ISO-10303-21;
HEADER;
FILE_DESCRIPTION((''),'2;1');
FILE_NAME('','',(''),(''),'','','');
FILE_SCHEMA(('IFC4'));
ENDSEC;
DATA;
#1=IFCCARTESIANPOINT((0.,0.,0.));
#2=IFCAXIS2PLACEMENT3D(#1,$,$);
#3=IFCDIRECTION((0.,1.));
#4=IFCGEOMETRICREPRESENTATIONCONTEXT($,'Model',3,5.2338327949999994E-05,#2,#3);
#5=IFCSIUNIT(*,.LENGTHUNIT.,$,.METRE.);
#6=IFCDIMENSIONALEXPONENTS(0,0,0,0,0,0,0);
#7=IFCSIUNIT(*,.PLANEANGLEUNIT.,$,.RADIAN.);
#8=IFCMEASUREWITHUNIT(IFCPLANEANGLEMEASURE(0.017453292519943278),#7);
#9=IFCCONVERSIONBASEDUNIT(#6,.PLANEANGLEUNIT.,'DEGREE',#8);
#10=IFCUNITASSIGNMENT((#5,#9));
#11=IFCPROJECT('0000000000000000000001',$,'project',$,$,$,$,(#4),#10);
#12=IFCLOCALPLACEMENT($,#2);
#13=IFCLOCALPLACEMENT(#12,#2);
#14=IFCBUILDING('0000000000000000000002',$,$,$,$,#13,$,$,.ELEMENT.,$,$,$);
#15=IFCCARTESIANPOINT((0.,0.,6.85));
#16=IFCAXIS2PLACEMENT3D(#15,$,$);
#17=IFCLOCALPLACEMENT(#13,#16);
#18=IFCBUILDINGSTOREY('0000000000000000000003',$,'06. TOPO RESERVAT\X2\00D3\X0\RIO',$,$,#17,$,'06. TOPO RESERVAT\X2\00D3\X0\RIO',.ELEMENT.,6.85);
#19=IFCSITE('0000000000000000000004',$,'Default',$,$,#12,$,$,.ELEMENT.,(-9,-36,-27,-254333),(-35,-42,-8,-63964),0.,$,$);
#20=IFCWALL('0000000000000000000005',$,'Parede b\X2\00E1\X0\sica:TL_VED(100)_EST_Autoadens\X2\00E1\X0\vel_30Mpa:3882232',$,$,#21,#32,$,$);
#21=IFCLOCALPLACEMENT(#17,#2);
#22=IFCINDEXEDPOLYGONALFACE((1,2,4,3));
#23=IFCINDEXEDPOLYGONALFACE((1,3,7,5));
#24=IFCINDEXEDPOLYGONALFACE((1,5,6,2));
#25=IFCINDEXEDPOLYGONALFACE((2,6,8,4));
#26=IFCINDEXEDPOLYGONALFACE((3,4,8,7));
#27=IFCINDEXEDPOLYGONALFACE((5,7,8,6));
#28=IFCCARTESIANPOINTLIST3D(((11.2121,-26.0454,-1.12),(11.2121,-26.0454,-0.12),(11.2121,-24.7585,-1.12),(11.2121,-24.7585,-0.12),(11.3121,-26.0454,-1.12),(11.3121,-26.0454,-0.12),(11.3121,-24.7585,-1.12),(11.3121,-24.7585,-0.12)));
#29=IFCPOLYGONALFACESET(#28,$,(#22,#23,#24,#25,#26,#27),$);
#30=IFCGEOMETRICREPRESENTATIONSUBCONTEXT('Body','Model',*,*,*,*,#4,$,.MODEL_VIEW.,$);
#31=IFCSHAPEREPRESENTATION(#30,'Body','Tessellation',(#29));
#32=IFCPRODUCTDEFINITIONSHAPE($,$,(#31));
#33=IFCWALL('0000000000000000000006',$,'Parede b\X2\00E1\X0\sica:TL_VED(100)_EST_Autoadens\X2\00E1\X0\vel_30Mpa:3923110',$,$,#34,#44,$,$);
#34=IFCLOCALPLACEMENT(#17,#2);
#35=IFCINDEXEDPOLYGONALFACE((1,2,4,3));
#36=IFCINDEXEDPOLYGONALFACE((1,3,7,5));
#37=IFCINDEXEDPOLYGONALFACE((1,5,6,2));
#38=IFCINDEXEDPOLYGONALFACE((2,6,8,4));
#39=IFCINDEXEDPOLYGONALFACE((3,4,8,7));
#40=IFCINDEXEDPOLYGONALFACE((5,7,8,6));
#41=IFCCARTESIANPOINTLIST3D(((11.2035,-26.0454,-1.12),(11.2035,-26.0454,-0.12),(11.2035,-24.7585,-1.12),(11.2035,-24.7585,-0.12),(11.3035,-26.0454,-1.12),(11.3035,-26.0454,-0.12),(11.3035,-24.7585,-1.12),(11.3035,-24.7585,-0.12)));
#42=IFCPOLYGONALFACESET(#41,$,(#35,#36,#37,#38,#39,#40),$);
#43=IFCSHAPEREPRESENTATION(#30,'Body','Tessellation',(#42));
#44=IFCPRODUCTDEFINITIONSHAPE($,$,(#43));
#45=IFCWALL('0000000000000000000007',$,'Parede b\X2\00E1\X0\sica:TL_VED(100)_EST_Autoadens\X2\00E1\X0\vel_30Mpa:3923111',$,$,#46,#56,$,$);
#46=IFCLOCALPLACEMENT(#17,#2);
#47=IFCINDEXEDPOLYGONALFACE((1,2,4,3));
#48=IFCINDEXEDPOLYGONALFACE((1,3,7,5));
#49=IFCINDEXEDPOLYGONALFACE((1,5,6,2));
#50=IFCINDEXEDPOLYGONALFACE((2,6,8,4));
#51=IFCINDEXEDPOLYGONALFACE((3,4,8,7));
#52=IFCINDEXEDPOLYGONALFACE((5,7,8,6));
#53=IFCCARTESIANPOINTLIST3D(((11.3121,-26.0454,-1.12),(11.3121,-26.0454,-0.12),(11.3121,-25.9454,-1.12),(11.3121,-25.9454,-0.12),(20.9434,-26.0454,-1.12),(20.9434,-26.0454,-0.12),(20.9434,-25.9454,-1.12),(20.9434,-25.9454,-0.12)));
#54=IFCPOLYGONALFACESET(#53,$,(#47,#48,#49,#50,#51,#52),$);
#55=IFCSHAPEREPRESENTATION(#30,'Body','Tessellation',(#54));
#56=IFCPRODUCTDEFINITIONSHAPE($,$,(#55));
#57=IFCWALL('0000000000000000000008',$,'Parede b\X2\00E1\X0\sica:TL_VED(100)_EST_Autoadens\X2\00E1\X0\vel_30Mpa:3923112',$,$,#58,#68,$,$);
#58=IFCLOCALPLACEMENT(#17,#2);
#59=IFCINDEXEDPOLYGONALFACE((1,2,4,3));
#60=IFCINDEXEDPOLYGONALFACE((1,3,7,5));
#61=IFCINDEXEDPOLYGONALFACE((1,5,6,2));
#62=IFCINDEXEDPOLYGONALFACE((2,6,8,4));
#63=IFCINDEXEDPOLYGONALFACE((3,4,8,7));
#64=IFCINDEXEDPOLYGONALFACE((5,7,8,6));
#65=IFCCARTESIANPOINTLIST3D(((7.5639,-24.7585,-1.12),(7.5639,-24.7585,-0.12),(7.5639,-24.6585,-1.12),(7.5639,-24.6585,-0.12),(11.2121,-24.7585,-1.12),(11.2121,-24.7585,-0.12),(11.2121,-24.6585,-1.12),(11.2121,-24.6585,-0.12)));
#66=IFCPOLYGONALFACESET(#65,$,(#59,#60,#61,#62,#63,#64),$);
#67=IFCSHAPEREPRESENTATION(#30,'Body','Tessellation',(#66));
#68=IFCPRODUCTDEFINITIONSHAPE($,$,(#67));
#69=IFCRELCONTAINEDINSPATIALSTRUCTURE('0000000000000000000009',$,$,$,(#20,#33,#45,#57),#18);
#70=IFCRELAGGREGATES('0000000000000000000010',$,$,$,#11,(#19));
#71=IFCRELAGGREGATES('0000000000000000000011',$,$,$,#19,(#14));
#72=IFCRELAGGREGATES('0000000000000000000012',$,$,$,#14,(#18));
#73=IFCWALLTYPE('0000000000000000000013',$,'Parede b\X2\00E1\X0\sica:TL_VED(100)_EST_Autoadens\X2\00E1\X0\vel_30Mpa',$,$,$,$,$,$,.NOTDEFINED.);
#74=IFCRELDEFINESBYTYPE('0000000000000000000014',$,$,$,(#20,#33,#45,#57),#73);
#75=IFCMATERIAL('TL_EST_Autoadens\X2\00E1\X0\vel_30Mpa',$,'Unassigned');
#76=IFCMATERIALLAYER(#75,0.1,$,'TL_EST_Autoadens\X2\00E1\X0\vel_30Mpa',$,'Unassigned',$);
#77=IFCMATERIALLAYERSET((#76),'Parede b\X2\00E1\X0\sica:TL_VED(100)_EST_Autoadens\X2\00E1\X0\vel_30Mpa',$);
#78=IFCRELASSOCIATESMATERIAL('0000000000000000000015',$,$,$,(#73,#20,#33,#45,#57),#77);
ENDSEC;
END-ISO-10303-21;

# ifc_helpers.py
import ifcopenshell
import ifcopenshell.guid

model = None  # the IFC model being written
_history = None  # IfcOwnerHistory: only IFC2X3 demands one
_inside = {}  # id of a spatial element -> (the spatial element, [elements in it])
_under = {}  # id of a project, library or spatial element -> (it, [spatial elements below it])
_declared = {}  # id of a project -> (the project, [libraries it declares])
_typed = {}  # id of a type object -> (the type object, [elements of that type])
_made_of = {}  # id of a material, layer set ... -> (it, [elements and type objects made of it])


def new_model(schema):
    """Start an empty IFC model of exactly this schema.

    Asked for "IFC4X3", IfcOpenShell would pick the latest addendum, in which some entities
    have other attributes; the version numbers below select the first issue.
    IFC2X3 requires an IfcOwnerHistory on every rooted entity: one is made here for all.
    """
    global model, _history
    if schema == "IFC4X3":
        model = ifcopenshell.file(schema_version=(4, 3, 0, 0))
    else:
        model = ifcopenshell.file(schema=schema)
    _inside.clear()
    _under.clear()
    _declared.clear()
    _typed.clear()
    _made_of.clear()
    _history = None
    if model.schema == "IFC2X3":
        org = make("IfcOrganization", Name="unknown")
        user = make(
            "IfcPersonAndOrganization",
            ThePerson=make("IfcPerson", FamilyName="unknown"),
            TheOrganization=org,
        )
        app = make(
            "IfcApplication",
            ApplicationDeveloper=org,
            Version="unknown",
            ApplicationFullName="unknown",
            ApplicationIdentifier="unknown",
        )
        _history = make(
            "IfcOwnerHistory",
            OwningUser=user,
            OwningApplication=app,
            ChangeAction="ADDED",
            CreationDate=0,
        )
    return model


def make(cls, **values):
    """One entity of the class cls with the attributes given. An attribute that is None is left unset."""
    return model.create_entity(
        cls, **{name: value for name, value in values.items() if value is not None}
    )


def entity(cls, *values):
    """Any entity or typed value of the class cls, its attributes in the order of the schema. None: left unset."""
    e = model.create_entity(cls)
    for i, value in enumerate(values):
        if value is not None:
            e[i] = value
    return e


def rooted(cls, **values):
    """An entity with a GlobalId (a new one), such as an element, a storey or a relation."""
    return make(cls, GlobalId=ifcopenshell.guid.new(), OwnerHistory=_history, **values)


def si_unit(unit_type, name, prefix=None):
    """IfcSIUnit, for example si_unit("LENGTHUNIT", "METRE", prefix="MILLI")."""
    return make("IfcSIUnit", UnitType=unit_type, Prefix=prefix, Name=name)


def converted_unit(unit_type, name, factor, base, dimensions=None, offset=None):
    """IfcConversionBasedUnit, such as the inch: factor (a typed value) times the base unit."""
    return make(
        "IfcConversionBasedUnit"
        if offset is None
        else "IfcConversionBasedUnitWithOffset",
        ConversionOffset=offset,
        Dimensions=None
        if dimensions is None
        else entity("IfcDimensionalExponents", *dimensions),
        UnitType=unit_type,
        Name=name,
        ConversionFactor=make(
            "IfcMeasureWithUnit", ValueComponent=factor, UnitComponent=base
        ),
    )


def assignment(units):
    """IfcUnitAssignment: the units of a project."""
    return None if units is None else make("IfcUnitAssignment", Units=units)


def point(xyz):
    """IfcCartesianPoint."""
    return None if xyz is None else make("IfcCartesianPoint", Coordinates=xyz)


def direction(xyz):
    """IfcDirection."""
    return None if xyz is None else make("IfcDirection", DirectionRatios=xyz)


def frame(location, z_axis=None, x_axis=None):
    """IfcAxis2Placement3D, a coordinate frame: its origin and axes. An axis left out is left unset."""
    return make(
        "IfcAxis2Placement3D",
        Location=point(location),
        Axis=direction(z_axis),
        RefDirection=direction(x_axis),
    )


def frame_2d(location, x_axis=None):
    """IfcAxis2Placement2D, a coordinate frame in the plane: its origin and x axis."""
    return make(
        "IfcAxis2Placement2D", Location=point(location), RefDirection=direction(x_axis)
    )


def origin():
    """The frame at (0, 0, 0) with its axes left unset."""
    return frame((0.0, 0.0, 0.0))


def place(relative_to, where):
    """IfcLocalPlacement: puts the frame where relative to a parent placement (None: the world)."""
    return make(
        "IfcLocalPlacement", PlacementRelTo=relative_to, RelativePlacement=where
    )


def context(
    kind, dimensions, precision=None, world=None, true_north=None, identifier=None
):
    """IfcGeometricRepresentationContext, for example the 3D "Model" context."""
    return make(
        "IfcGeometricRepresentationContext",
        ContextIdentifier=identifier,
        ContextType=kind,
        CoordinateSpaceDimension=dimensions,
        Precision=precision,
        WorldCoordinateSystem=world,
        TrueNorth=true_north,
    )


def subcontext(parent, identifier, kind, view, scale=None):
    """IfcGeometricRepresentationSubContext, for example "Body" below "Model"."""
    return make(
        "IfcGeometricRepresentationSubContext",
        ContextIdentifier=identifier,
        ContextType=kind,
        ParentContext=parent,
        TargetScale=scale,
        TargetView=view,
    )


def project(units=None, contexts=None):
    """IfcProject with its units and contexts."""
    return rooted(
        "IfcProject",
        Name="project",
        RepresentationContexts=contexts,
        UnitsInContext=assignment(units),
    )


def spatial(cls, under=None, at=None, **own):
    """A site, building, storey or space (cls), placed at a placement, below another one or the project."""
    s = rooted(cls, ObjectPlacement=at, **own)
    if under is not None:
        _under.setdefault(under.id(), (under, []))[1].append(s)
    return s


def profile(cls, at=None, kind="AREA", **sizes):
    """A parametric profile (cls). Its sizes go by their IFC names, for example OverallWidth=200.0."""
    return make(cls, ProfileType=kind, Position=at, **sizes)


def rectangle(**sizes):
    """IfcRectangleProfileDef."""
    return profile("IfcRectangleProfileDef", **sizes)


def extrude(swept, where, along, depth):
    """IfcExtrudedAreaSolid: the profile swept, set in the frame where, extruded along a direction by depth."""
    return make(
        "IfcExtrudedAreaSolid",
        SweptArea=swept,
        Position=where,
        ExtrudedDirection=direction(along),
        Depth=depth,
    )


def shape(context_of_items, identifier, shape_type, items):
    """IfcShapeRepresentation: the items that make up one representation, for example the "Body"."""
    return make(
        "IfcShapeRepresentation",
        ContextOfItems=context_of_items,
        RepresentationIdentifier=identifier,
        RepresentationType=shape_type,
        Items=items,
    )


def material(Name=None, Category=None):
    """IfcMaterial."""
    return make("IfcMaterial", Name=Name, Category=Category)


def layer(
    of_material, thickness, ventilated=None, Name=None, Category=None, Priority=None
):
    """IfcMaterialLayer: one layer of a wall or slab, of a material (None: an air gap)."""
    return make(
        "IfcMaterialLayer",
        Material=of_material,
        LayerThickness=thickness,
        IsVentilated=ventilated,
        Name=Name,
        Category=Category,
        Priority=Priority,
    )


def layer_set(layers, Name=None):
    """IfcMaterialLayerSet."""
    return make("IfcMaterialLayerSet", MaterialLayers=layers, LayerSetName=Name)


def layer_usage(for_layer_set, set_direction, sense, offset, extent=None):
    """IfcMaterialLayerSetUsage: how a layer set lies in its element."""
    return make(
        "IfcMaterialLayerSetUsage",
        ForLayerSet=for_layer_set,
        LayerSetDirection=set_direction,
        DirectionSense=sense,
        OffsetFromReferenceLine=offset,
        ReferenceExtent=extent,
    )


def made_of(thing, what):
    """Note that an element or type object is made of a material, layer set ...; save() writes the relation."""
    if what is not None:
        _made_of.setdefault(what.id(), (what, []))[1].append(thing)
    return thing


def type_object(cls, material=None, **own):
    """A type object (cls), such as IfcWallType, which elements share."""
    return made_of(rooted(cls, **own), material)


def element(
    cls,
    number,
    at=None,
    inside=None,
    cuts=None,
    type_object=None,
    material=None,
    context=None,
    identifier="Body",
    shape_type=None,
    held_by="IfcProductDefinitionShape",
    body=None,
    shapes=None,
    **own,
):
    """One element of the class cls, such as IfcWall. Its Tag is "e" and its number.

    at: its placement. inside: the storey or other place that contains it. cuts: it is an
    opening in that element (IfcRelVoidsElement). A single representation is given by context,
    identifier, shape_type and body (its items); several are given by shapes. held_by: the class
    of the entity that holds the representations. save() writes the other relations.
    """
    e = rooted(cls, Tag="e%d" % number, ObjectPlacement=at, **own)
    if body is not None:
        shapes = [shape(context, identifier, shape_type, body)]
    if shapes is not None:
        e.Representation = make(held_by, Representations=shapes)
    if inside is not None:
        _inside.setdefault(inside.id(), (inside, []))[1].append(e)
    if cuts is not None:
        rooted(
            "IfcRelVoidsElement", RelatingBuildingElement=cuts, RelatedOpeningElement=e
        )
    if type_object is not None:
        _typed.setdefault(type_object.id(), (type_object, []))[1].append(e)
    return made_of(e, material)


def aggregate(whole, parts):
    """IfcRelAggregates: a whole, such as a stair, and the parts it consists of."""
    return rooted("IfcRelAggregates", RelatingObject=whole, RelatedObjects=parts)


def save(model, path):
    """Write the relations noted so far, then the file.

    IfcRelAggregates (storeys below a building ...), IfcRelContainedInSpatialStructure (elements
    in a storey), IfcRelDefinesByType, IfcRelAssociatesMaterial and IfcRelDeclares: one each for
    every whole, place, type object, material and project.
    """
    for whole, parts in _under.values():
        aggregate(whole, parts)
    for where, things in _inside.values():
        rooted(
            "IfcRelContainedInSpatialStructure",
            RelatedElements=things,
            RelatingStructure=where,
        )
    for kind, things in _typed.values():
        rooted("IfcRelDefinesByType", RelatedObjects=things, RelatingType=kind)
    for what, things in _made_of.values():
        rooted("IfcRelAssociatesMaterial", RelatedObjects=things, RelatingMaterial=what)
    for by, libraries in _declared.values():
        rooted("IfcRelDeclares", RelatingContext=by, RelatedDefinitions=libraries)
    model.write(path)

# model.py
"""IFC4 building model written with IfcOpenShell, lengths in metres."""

from ifc_helpers import new_model, entity, si_unit, converted_unit, direction, frame, frame_2d, origin, place, context, subcontext, project, spatial, rectangle, extrude, material, layer, layer_set, layer_usage, type_object, element, save


model = new_model("IFC4")

# Units and contexts
model_context = context("Model", 3, precision=5.2338327949999994e-05, world=origin(), true_north=direction((0.0, 1.0)))
body_context = subcontext(model_context, "Body", "Model", "MODEL_VIEW")
ifc_project = project(units=[si_unit("LENGTHUNIT", "METRE"), converted_unit("PLANEANGLEUNIT", "DEGREE", entity("IfcPlaneAngleMeasure", 0.017453292519943278), si_unit("PLANEANGLEUNIT", "RADIAN"), dimensions=[0, 0, 0, 0, 0, 0, 0])], contexts=[model_context])

# Site, building, storey
site_placement = place(None, frame((0.0, 0.0, 0.0)))
site = spatial("IfcSite", under=ifc_project, at=site_placement, Name="Default", CompositionType="ELEMENT", RefLatitude=(-9, -36, -27, -254333), RefLongitude=(-35, -42, -8, -63964), RefElevation=0.0)
building_placement = place(site_placement, origin())
building = spatial("IfcBuilding", under=site, at=building_placement, CompositionType="ELEMENT")
storey_placement = place(building_placement, frame((0.0, 0.0, 6.85)))
storey = spatial("IfcBuildingStorey", under=building, at=storey_placement, Name="06. TOPO RESERVATÓRIO", LongName="06. TOPO RESERVATÓRIO", CompositionType="ELEMENT", Elevation=6.85)

# Walls
ifc_material_1 = material(Name="TL_EST_Autoadensável_30Mpa", Category="Unassigned")
ifc_layer = layer(ifc_material_1, 0.1, Name="TL_EST_Autoadensável_30Mpa", Category="Unassigned")
ifc_layer_set = layer_set([ifc_layer], Name="Parede básica:TL_VED(100)_EST_Autoadensável_30Mpa")
ifc_layer_usage_1 = layer_usage(ifc_layer_set, "AXIS2", "NEGATIVE", 0.05)
wall_type = type_object("IfcWallType", Name="Parede básica:TL_VED(100)_EST_Autoadensável_30Mpa", PredefinedType="NOTDEFINED", material=ifc_layer_set)
wall_1_placement = place(storey_placement, frame((11.2621, -24.7585, -1.12), z_axis=(0.0, 0.0, 1.0), x_axis=(0.0, -1.0, 0.0)))
element("IfcWall", 1, at=wall_1_placement, inside=storey, type_object=wall_type, material=ifc_layer_usage_1, Name="Parede básica:TL_VED(100)_EST_Autoadensável_30Mpa:3882232", context=body_context, shape_type="SweptSolid", body=[
    extrude(rectangle(XDim=1.2869, YDim=0.1, at=frame_2d((0.6434, 0.0), x_axis=(-1.0, 0.0))), origin(), (0.0, 0.0, 1.0), 1.0),
])
ifc_layer_usage_2 = layer_usage(ifc_layer_set, "AXIS2", "NEGATIVE", 0.05)
wall_2_placement = place(storey_placement, frame((11.2535, -24.7585, -1.12), z_axis=(0.0, 0.0, 1.0), x_axis=(0.0, -1.0, 0.0)))
element("IfcWall", 2, at=wall_2_placement, inside=storey, type_object=wall_type, material=ifc_layer_usage_2, Name="Parede básica:TL_VED(100)_EST_Autoadensável_30Mpa:3923110", context=body_context, shape_type="SweptSolid", body=[
    extrude(rectangle(XDim=1.2869, YDim=0.1, at=frame_2d((0.6434, 0.0), x_axis=(-1.0, 0.0))), origin(), (0.0, 0.0, 1.0), 1.0),
])
ifc_layer_usage_3 = layer_usage(ifc_layer_set, "AXIS2", "NEGATIVE", 0.05)
wall_3_placement = place(storey_placement, frame((11.3121, -25.9954, -1.12)))
element("IfcWall", 3, at=wall_3_placement, inside=storey, type_object=wall_type, material=ifc_layer_usage_3, Name="Parede básica:TL_VED(100)_EST_Autoadensável_30Mpa:3923111", context=body_context, shape_type="SweptSolid", body=[
    extrude(rectangle(XDim=9.6313, YDim=0.1, at=frame_2d((4.8156, 0.0), x_axis=(-1.0, 0.0))), origin(), (0.0, 0.0, 1.0), 1.0),
])
ifc_layer_usage_4 = layer_usage(ifc_layer_set, "AXIS2", "NEGATIVE", 0.05)
wall_4_placement = place(storey_placement, frame((11.2121, -24.7085, -1.12), z_axis=(0.0, 0.0, 1.0), x_axis=(-1.0, 0.0, 0.0)))
element("IfcWall", 4, at=wall_4_placement, inside=storey, type_object=wall_type, material=ifc_layer_usage_4, Name="Parede básica:TL_VED(100)_EST_Autoadensável_30Mpa:3923112", context=body_context, shape_type="SweptSolid", body=[
    extrude(rectangle(XDim=3.6482, YDim=0.1, at=frame_2d((1.8241, 0.0), x_axis=(-1.0, 0.0))), origin(), (0.0, 0.0, 1.0), 1.0),
])

save(model, "model.ifc")
